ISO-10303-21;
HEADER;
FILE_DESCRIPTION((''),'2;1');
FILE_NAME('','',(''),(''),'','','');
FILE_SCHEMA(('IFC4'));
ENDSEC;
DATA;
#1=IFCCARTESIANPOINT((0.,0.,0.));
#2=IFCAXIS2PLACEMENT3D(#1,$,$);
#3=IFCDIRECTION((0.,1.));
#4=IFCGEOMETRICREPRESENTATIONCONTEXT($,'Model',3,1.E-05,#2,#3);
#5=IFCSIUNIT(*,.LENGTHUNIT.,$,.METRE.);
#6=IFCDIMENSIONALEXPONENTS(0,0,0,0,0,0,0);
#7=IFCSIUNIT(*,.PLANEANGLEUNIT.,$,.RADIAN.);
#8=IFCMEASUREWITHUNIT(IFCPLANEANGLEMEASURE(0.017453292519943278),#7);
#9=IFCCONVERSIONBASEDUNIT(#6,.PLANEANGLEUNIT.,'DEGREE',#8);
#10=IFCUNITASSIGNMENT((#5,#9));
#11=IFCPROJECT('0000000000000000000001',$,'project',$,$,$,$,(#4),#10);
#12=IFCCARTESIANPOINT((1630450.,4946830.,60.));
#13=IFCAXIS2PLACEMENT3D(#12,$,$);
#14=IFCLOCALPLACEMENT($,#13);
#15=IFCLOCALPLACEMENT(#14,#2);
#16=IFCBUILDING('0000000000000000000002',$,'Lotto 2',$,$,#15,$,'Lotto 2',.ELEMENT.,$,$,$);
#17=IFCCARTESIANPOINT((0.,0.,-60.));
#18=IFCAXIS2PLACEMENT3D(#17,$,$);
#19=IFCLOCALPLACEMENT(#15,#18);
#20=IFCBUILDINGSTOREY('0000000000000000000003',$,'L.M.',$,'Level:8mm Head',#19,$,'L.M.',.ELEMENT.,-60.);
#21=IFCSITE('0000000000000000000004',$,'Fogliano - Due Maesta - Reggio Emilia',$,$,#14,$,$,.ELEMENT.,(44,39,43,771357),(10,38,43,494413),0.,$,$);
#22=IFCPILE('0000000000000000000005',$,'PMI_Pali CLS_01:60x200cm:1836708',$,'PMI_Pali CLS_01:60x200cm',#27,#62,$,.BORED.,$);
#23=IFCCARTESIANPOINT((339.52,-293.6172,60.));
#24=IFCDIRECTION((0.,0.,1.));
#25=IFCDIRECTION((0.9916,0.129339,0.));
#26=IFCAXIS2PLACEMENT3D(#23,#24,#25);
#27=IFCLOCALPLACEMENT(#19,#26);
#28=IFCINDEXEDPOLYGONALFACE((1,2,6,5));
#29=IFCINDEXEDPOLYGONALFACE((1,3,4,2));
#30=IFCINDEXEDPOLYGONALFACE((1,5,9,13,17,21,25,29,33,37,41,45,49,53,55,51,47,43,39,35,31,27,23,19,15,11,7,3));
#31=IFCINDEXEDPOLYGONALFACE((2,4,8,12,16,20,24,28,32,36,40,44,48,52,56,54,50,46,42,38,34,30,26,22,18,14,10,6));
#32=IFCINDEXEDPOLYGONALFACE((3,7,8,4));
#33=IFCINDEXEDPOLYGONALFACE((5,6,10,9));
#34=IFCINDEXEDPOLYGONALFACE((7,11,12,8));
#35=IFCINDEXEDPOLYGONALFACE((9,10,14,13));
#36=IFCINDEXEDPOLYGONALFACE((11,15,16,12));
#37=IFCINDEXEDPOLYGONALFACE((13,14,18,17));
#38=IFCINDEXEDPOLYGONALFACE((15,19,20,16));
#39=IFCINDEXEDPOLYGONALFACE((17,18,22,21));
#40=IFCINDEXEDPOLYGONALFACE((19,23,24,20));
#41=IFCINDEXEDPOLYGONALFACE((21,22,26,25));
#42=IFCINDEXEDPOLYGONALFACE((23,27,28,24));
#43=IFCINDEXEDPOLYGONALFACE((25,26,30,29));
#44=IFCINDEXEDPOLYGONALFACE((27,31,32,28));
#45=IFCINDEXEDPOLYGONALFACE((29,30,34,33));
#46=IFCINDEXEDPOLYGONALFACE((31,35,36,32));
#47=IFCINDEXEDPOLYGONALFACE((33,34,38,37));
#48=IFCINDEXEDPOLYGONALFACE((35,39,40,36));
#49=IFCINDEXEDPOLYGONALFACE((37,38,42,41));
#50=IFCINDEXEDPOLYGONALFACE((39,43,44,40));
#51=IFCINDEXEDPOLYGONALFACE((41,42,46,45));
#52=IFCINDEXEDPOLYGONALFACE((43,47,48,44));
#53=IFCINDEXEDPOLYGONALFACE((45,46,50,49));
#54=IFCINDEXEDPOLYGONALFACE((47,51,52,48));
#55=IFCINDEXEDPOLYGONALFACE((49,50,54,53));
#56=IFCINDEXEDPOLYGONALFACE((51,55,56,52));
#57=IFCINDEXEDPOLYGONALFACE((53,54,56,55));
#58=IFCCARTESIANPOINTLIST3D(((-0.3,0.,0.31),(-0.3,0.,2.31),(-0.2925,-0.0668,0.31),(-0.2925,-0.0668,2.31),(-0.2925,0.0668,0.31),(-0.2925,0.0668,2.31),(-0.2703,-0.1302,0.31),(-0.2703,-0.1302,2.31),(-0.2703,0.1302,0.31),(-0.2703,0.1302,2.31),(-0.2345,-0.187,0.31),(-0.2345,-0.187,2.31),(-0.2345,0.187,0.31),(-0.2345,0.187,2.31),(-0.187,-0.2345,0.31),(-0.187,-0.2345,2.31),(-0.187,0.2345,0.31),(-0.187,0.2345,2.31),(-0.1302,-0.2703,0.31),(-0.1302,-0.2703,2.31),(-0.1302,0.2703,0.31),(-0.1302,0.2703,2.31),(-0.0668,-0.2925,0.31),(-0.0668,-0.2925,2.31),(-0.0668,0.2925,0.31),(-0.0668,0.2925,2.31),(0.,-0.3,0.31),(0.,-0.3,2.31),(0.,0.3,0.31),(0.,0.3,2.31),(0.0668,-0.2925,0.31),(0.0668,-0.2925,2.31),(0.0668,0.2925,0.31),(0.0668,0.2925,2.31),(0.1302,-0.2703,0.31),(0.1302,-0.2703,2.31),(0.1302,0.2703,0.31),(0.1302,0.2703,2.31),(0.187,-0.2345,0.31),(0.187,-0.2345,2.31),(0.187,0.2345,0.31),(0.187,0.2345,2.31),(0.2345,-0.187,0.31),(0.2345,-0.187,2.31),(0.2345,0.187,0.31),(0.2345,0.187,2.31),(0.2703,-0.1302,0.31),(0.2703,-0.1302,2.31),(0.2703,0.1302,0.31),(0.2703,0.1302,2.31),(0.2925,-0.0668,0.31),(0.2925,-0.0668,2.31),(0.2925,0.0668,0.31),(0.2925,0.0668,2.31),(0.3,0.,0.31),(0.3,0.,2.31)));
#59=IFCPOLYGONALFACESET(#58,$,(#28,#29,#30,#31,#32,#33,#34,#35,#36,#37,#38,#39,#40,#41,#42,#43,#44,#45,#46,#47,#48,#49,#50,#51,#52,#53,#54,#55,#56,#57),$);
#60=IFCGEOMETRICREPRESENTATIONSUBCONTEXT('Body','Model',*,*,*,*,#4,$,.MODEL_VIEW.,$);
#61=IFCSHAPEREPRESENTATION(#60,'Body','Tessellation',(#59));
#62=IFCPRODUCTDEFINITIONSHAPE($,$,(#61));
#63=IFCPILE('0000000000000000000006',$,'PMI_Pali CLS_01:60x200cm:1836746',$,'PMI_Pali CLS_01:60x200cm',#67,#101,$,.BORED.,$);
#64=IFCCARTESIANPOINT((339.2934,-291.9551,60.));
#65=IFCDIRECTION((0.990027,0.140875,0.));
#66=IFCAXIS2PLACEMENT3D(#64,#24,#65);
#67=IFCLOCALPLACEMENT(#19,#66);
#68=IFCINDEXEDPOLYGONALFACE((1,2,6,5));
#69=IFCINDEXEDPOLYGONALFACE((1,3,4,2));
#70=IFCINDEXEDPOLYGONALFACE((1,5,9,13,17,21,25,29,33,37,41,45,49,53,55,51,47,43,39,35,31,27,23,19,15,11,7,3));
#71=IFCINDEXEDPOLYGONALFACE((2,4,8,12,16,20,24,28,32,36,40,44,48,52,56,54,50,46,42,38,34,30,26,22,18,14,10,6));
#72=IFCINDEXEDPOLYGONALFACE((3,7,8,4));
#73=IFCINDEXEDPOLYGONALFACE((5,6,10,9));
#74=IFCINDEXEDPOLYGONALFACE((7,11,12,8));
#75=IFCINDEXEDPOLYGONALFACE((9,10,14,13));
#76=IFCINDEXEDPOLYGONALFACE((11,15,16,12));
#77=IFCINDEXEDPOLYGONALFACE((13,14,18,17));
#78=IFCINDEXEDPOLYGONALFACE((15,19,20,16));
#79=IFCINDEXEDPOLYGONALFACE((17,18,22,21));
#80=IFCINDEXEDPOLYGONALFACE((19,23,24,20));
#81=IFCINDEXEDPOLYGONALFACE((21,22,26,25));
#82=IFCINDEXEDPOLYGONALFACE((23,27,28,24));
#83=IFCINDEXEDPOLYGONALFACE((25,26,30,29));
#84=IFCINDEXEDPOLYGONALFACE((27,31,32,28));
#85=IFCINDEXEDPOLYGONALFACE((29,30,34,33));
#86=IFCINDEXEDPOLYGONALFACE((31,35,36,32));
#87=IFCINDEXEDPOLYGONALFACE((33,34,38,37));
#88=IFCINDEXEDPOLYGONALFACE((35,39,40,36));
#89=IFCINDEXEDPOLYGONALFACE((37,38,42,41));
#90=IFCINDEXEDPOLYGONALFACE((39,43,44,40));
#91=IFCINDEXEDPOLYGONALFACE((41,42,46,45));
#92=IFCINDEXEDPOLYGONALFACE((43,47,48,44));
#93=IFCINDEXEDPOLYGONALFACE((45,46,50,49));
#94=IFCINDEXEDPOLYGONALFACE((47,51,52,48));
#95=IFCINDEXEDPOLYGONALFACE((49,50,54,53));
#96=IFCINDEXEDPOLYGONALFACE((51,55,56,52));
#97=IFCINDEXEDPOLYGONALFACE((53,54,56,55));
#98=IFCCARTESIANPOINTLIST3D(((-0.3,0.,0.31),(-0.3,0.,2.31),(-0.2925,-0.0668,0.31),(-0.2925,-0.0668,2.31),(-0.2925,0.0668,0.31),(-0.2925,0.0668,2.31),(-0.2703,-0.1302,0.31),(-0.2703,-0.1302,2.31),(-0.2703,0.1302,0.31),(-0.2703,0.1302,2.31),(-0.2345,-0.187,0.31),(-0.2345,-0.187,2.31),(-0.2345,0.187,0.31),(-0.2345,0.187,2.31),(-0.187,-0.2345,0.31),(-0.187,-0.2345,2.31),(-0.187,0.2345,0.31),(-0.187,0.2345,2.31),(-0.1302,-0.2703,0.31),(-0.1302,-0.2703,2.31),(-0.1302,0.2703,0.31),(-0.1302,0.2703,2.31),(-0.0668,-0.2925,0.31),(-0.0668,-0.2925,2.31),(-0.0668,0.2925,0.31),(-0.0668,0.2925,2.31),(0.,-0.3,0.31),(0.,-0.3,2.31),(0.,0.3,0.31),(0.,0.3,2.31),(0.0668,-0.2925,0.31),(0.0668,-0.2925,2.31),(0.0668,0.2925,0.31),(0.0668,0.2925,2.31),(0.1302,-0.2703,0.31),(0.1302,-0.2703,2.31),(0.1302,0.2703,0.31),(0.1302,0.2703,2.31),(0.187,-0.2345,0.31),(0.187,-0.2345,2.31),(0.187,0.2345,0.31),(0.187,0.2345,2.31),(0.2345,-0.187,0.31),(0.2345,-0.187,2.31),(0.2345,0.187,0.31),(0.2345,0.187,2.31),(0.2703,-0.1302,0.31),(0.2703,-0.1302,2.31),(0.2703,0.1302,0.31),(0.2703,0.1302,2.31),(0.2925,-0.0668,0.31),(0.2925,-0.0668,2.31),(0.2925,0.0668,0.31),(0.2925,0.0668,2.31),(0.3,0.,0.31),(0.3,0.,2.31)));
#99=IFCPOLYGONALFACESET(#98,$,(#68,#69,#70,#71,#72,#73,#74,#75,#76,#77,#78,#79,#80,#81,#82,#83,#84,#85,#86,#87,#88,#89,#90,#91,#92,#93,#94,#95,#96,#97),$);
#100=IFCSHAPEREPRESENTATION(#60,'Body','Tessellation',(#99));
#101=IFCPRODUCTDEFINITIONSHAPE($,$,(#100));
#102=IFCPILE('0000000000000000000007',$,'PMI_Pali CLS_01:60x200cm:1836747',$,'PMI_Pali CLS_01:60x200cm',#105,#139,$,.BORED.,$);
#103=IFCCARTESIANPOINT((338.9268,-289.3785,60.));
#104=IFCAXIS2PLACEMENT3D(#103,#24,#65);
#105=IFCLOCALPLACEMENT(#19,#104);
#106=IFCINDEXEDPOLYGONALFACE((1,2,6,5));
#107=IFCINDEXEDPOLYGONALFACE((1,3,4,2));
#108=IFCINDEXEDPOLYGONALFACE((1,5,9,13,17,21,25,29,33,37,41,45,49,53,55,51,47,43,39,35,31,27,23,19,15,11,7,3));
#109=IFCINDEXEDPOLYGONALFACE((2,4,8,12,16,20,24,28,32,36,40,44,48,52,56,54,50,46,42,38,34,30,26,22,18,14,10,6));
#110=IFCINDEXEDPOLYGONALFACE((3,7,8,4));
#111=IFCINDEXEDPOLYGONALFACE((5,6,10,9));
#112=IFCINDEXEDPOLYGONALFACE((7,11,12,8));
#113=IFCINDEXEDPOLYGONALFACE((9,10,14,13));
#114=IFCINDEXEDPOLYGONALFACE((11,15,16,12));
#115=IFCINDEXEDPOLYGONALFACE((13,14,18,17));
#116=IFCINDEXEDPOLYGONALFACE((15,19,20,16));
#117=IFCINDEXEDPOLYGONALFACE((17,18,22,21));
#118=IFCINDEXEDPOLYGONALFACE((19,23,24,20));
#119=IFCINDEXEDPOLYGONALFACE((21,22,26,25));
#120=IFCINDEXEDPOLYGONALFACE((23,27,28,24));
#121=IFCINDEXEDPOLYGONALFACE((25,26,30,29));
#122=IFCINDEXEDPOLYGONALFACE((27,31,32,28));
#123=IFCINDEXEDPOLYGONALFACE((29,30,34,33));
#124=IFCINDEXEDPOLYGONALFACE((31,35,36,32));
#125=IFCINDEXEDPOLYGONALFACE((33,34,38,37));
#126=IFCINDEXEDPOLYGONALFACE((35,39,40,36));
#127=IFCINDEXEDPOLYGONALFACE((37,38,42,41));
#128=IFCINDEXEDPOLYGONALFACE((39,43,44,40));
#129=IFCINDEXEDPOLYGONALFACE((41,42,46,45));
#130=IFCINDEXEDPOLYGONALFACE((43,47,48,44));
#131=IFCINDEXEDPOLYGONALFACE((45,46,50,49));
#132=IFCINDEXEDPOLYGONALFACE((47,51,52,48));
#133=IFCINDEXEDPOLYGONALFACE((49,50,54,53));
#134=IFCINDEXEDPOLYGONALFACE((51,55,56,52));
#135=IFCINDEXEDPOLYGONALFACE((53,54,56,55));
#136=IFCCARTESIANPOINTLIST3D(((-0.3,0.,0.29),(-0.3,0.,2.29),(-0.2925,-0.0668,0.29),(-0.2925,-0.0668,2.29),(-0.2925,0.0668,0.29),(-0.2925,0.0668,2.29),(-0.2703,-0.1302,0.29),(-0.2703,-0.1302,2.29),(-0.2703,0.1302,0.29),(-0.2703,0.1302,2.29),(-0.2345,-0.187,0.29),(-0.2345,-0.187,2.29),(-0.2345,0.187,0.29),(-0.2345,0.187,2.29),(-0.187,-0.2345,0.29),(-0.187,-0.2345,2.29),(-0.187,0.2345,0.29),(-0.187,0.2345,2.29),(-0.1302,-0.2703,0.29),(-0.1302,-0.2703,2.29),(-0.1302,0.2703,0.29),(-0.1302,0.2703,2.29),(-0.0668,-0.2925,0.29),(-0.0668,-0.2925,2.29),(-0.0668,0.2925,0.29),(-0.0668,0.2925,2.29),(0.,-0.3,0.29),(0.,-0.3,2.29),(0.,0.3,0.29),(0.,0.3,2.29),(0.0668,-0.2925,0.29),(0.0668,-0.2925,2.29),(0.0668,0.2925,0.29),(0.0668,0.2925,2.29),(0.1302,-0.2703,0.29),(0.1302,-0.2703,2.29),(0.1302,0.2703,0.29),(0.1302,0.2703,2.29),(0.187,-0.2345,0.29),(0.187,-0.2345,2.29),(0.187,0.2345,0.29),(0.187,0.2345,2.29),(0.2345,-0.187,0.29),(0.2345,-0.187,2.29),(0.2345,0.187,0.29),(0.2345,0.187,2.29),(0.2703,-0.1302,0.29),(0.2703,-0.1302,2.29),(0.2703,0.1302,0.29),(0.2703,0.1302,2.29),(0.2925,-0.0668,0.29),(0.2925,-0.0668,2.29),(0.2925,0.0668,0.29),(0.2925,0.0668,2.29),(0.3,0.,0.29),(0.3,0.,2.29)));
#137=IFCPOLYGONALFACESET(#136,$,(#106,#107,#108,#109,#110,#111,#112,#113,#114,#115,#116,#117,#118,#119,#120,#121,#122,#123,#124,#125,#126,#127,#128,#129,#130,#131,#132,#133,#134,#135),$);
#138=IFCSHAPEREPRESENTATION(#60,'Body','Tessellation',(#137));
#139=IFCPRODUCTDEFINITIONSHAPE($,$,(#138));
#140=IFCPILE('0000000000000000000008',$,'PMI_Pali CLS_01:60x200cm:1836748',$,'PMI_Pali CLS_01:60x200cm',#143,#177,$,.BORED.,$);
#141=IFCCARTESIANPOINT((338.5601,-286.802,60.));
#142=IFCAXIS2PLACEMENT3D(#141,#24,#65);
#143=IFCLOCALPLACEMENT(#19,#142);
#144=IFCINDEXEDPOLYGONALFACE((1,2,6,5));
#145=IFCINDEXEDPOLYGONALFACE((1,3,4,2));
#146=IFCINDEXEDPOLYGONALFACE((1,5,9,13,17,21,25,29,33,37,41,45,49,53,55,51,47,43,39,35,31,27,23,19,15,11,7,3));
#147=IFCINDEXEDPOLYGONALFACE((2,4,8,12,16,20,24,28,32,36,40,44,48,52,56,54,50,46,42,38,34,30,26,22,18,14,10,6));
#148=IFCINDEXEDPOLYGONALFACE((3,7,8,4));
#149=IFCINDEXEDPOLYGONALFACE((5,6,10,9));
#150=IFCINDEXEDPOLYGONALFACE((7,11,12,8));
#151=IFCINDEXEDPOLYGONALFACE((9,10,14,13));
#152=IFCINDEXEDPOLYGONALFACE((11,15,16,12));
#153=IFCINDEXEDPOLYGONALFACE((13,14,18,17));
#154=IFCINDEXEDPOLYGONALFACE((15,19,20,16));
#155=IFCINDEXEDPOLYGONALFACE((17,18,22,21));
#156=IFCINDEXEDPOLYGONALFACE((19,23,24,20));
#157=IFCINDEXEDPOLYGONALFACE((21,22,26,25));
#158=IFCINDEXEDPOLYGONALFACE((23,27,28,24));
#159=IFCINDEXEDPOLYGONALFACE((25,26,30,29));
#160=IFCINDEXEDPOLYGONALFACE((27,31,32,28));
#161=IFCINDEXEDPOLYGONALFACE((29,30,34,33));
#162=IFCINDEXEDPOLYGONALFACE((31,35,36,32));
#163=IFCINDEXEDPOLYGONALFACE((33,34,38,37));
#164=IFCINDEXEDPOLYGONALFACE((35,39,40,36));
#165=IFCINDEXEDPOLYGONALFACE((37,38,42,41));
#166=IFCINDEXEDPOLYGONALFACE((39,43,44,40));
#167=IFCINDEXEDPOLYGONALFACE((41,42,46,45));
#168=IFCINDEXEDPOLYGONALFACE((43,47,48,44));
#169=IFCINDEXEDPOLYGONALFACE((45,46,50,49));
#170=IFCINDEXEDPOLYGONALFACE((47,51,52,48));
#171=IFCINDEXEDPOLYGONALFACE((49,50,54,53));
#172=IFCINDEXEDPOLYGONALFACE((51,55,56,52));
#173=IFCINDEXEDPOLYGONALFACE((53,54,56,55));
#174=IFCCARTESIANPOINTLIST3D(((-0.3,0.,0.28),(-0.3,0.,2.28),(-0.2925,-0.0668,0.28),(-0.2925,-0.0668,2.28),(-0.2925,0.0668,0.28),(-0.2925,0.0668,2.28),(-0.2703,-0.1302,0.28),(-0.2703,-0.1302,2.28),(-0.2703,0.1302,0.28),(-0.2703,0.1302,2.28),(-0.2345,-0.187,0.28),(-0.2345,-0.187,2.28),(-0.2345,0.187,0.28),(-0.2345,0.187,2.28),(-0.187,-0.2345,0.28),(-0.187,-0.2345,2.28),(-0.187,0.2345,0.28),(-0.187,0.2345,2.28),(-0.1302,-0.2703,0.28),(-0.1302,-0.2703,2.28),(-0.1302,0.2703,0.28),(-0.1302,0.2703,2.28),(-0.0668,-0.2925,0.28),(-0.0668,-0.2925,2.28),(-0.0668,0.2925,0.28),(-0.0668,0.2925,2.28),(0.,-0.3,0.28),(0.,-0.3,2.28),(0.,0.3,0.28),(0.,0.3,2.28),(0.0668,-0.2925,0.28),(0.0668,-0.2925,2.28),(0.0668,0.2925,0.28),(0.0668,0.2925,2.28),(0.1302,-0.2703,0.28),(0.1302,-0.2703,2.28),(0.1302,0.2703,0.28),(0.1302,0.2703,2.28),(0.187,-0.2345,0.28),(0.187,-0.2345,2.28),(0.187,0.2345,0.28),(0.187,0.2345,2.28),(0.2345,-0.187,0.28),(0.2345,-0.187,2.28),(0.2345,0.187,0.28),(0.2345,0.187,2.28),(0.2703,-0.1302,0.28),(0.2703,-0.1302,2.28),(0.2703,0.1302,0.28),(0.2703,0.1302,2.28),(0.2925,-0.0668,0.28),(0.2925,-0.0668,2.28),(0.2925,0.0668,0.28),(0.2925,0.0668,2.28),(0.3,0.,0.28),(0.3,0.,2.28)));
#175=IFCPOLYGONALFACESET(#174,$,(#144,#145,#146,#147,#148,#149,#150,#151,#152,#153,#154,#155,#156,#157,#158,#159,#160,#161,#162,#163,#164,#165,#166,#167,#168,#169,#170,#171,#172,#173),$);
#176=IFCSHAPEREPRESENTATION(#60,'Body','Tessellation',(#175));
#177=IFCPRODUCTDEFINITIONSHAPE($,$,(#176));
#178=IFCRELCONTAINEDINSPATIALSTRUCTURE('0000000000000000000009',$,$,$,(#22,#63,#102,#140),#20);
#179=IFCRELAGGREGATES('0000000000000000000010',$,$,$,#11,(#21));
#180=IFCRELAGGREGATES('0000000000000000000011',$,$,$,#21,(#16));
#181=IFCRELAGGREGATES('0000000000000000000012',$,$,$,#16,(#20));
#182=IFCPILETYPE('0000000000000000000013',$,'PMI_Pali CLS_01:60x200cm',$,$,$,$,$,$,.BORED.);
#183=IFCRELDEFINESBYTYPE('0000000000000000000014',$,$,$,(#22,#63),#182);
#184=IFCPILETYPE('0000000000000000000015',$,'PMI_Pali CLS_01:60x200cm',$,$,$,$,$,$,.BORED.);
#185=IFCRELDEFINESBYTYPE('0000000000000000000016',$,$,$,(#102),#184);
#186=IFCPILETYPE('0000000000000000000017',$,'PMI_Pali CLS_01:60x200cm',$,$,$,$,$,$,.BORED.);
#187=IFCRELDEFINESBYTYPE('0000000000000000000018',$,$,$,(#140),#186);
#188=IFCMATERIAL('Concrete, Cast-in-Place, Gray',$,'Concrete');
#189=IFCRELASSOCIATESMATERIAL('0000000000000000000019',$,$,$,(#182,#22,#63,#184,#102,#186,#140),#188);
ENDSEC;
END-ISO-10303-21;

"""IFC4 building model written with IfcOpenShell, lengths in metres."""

from ifc_helpers import new_model, entity, si_unit, converted_unit, direction, frame, origin, place, context, subcontext, project, spatial, arc, indexed_curve, outline, extrude, source, transform, mapped, material, type_object, type_shapes, element, save


model = new_model("IFC4")

# Units and contexts
model_context = context("Model", 3, precision=1e-05, world=origin(), true_north=direction((0.0, 1.0)))
body_context = subcontext(model_context, "Body", "Model", "MODEL_VIEW")
ifc_project = project(units=[si_unit("LENGTHUNIT", "METRE"), converted_unit("PLANEANGLEUNIT", "DEGREE", entity("IfcPlaneAngleMeasure", 0.017453292519943278), si_unit("PLANEANGLEUNIT", "RADIAN"), dimensions=[0, 0, 0, 0, 0, 0, 0])], contexts=[model_context])

# Site, building, storey
site_placement = place(None, frame((1630450.0, 4946830.0, 60.0)))
site = spatial("IfcSite", under=ifc_project, at=site_placement, Name="Fogliano - Due Maesta - Reggio Emilia", CompositionType="ELEMENT", RefLatitude=(44, 39, 43, 771357), RefLongitude=(10, 38, 43, 494413), RefElevation=0.0)
building_placement = place(site_placement, origin())
building = spatial("IfcBuilding", under=site, at=building_placement, Name="Lotto 2", LongName="Lotto 2", CompositionType="ELEMENT")
storey_placement = place(building_placement, frame((0.0, 0.0, -60.0)))
storey = spatial("IfcBuildingStorey", under=building, at=storey_placement, Name="L.M.", ObjectType="Level:8mm Head", LongName="L.M.", CompositionType="ELEMENT", Elevation=-60.0)

# Piles
ifc_material_1 = material(Name="Concrete, Cast-in-Place, Gray", Category="Concrete")
pile_type_1 = type_object("IfcPileType", Name="PMI_Pali CLS_01:60x200cm", PredefinedType="BORED", material=ifc_material_1)
shared_shape_1 = source(origin(), body_context, "Body", "SweptSolid", [
    extrude(outline(indexed_curve([(-0.3, 0.0), (0.0, -0.3), (0.3, 0.0), (0.0, 0.3)], segments=[arc(1, 2, 3), arc(3, 4, 1)], self_intersect=False)), frame((0.0, 0.0, 0.31)), (0.0, 0.0, 1.0), 2.0),
])
type_shapes(pile_type_1, [shared_shape_1])
for number, where, z_axis, x_axis, name in (
    (1, (339.52, -293.6172, 60.0), (0.0, 0.0, 1.0), (0.9916, 0.129339, 0.0), "PMI_Pali CLS_01:60x200cm:1836708"),
    (2, (339.2934, -291.9551, 60.0), (0.0, 0.0, 1.0), (0.990027, 0.140875, 0.0), "PMI_Pali CLS_01:60x200cm:1836746"),
):
    element("IfcPile", number, at=place(storey_placement, frame(where, z_axis=z_axis, x_axis=x_axis)), inside=storey, type_object=pile_type_1, material=ifc_material_1, Name=name, ObjectType="PMI_Pali CLS_01:60x200cm", PredefinedType="BORED", context=body_context, shape_type="MappedRepresentation", body=[
        mapped(shared_shape_1, transform((0.0, 0.0, 0.0), scale=1.0)),
    ])
pile_type_2 = type_object("IfcPileType", Name="PMI_Pali CLS_01:60x200cm", PredefinedType="BORED", material=ifc_material_1)
shared_shape_2 = source(origin(), body_context, "Body", "SweptSolid", [
    extrude(outline(indexed_curve([(-0.3, 0.0), (0.0, -0.3), (0.3, 0.0), (0.0, 0.3)], segments=[arc(1, 2, 3), arc(3, 4, 1)], self_intersect=False)), frame((0.0, 0.0, 0.29)), (0.0, 0.0, 1.0), 2.0),
])
type_shapes(pile_type_2, [shared_shape_2])
pile_1_placement = place(storey_placement, frame((338.9268, -289.3785, 60.0), z_axis=(0.0, 0.0, 1.0), x_axis=(0.990027, 0.140875, 0.0)))
element("IfcPile", 3, at=pile_1_placement, inside=storey, type_object=pile_type_2, material=ifc_material_1, Name="PMI_Pali CLS_01:60x200cm:1836747", ObjectType="PMI_Pali CLS_01:60x200cm", PredefinedType="BORED", context=body_context, shape_type="MappedRepresentation", body=[
    mapped(shared_shape_2, transform((0.0, 0.0, 0.0), scale=1.0)),
])
pile_type_3 = type_object("IfcPileType", Name="PMI_Pali CLS_01:60x200cm", PredefinedType="BORED", material=ifc_material_1)
shared_shape_3 = source(origin(), body_context, "Body", "SweptSolid", [
    extrude(outline(indexed_curve([(-0.3, 0.0), (0.0, -0.3), (0.3, 0.0), (0.0, 0.3)], segments=[arc(1, 2, 3), arc(3, 4, 1)], self_intersect=False)), frame((0.0, 0.0, 0.28)), (0.0, 0.0, 1.0), 2.0),
])
type_shapes(pile_type_3, [shared_shape_3])
pile_2_placement = place(storey_placement, frame((338.5601, -286.802, 60.0), z_axis=(0.0, 0.0, 1.0), x_axis=(0.990027, 0.140875, 0.0)))
element("IfcPile", 4, at=pile_2_placement, inside=storey, type_object=pile_type_3, material=ifc_material_1, Name="PMI_Pali CLS_01:60x200cm:1836748", ObjectType="PMI_Pali CLS_01:60x200cm", PredefinedType="BORED", context=body_context, shape_type="MappedRepresentation", body=[
    mapped(shared_shape_3, transform((0.0, 0.0, 0.0), scale=1.0)),
])

save(model, "model.ifc")
